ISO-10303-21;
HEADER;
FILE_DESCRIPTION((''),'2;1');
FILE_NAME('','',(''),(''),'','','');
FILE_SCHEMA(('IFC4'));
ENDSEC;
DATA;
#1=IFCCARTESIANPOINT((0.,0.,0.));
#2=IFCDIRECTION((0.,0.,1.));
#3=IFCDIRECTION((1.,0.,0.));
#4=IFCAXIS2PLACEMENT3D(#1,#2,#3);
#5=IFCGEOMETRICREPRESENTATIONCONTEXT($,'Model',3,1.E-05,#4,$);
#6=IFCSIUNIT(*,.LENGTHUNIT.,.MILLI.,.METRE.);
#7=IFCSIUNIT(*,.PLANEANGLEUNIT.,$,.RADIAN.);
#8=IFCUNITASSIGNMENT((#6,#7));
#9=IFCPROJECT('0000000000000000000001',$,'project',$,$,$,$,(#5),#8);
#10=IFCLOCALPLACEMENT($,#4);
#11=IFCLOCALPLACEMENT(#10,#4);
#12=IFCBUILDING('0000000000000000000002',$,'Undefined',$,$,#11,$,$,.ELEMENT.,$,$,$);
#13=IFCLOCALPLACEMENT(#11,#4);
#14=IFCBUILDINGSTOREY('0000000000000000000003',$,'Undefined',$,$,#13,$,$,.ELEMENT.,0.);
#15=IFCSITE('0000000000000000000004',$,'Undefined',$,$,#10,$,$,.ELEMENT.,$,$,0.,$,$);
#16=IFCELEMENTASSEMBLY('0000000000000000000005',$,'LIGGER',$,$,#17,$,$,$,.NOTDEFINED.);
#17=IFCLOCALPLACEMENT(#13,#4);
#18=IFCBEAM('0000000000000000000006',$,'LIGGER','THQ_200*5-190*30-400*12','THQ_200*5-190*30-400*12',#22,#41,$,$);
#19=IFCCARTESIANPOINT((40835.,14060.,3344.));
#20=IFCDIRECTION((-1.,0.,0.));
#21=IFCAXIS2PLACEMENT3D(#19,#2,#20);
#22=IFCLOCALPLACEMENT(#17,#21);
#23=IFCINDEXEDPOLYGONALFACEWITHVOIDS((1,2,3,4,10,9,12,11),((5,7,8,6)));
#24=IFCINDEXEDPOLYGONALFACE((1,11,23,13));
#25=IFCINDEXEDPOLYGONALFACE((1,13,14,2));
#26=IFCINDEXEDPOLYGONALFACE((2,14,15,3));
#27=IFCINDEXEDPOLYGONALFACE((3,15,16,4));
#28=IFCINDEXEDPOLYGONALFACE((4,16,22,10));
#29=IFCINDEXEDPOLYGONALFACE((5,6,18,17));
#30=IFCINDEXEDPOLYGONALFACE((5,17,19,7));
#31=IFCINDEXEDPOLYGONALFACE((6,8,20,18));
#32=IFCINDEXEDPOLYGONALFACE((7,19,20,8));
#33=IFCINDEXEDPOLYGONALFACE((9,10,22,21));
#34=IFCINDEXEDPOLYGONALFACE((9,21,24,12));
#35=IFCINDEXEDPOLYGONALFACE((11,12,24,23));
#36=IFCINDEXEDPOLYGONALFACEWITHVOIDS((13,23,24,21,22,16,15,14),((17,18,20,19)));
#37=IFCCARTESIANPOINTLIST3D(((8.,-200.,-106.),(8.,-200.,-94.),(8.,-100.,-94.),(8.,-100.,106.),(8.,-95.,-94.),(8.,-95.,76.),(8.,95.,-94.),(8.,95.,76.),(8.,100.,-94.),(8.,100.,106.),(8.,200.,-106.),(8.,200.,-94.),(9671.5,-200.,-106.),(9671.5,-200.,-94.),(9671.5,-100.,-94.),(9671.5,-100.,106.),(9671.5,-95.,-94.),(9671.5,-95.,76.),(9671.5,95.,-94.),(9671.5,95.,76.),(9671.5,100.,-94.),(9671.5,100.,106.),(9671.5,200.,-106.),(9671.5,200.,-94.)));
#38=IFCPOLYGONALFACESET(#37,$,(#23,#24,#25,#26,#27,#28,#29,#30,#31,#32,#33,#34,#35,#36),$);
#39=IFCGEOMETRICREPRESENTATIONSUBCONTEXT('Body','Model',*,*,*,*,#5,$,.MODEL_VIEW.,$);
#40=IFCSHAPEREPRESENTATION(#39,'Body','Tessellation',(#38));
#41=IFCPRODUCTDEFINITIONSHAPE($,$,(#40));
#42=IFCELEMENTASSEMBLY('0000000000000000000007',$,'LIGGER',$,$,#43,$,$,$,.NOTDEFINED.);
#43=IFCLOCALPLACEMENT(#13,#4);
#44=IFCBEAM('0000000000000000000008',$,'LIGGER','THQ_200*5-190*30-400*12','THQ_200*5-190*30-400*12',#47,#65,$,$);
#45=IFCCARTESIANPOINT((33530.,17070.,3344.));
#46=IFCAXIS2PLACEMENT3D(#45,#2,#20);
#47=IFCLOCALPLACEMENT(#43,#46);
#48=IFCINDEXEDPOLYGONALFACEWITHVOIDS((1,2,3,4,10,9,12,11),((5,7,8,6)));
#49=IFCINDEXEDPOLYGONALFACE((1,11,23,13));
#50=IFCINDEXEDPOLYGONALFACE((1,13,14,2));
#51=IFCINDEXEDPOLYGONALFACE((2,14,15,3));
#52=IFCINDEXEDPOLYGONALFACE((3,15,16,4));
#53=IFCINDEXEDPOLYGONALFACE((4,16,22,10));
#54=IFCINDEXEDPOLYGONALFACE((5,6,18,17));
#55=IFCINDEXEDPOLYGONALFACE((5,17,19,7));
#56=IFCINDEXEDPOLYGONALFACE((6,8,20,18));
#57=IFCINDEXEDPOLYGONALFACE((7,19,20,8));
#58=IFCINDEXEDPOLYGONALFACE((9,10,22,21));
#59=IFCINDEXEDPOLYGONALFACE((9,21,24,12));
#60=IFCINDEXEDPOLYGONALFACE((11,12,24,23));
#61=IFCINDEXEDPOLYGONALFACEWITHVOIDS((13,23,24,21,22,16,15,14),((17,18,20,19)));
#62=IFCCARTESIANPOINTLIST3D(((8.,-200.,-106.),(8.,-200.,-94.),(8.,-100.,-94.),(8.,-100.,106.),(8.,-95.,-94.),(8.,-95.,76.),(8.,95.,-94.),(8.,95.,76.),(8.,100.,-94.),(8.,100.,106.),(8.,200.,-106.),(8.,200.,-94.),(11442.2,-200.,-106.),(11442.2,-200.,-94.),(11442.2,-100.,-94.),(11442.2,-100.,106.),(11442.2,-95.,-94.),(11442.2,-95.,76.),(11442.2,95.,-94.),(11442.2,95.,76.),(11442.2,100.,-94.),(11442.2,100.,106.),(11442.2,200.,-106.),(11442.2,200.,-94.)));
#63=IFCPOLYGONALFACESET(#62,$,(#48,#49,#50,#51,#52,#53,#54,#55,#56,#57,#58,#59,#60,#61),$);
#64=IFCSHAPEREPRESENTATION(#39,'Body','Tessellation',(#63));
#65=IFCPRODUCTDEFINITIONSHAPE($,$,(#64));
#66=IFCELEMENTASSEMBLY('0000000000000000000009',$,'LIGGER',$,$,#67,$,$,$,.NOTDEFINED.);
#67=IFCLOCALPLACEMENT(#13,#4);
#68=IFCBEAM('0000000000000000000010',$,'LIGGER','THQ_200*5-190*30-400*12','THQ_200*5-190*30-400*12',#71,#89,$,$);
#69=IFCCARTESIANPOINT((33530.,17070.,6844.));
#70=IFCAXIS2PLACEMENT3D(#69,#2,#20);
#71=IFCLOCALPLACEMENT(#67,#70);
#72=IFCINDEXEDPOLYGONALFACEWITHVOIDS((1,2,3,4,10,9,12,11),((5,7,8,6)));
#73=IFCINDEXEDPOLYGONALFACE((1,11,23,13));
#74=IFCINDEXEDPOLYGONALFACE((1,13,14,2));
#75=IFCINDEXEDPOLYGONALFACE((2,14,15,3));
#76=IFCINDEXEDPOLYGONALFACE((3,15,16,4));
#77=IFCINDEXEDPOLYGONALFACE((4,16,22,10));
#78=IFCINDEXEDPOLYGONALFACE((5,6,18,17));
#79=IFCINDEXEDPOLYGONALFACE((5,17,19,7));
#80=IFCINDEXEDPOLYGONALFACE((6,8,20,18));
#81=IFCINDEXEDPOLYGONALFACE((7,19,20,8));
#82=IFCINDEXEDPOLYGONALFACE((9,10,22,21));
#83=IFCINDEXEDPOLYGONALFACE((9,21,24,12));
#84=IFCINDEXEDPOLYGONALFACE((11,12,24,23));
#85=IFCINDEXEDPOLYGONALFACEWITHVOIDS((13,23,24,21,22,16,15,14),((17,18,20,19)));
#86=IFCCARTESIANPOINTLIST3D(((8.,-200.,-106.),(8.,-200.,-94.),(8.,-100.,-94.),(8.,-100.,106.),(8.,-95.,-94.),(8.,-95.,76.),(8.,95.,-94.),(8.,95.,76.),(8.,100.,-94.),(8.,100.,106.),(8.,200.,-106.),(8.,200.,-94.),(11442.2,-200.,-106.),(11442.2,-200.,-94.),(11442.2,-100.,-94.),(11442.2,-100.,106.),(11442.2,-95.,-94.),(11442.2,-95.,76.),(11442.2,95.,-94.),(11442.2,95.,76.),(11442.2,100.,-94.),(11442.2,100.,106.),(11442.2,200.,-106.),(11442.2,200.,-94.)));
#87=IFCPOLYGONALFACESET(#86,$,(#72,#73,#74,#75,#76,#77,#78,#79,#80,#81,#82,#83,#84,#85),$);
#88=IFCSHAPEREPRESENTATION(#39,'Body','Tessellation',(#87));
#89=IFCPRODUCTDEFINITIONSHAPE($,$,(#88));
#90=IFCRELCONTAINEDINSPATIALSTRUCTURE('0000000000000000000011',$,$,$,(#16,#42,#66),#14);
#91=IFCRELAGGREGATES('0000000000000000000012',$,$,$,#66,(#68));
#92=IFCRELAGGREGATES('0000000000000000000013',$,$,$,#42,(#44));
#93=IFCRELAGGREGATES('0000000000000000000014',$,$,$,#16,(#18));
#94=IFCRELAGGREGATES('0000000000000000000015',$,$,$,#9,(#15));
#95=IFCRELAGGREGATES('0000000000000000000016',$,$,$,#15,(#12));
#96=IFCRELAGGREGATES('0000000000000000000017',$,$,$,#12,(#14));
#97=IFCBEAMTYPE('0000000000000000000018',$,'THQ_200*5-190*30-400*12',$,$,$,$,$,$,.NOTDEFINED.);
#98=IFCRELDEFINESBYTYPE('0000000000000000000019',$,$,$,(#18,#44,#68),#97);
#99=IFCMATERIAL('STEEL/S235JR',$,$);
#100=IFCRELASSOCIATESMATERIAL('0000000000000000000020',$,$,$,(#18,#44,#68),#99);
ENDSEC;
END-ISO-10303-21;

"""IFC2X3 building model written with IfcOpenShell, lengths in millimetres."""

from ifc_helpers import new_model, si_unit, frame, origin_with_axes, place, context, subcontext, project, spatial, polyline, outline, extrude, material, type_object, element, aggregate, save


model = new_model("IFC2X3")

# Units and contexts
model_context = context("Model", 3, precision=1e-05, world=origin_with_axes())
body_context = subcontext(model_context, "Body", "Model", "MODEL_VIEW")
ifc_project = project(units=[si_unit("LENGTHUNIT", "METRE", prefix="MILLI"), si_unit("PLANEANGLEUNIT", "RADIAN")], contexts=[model_context])

# Site, building, storey
site_placement = place(None, origin_with_axes())
site = spatial("IfcSite", under=ifc_project, at=site_placement, Name="Undefined", CompositionType="ELEMENT", RefElevation=0.0)
building_placement = place(site_placement, origin_with_axes())
building = spatial("IfcBuilding", under=site, at=building_placement, Name="Undefined", CompositionType="ELEMENT")
storey_placement = place(building_placement, origin_with_axes())
storey = spatial("IfcBuildingStorey", under=building, at=storey_placement, Name="Undefined", CompositionType="ELEMENT", Elevation=0.0)

# Shared definitions
ifc_material = material(Name="STEEL/S235JR")

# Element assemblies, beams
assembly_1_placement = place(storey_placement, origin_with_axes())
assembly_1 = element("IfcElementAssembly", 1, at=assembly_1_placement, inside=storey, Name="LIGGER", PredefinedType="NOTDEFINED")
beam_type_1 = type_object("IfcBeamType", Name="THQ_200*5-190*30-400*12", PredefinedType="NOTDEFINED")
beam_1_placement = place(assembly_1_placement, frame((40835.0, 14060.0, 3344.0), z_axis=(0.0, 0.0, 1.0), x_axis=(-1.0, 0.0, 0.0)))
beam_1 = element("IfcBeam", 2, at=beam_1_placement, type_object=beam_type_1, material=ifc_material, Name="LIGGER", Description="THQ_200*5-190*30-400*12", ObjectType="THQ_200*5-190*30-400*12", context=body_context, shape_type="SweptSolid", body=[
    extrude(outline(polyline([(100.0, -94.0), (200.0, -94.0), (200.0, -106.0), (-200.0, -106.0), (-200.0, -94.0), (-100.0, -94.0), (-100.0, 106.0), (100.0, 106.0), (100.0, -94.0)]), holes=[polyline([(95.0, -94.0), (95.0, 76.0), (-95.0, 76.0), (-95.0, -94.0), (95.0, -94.0)])]), frame((9671.5, 0.0, 0.0), z_axis=(-1.0, 0.0, 0.0), x_axis=(0.0, -1.0, 0.0)), (0.0, 0.0, 1.0), 9663.5),
])
assembly_2_placement = place(storey_placement, origin_with_axes())
assembly_2 = element("IfcElementAssembly", 3, at=assembly_2_placement, inside=storey, Name="LIGGER", PredefinedType="NOTDEFINED")
beam_2_placement = place(assembly_2_placement, frame((33530.0, 17070.0, 3344.0), z_axis=(0.0, 0.0, 1.0), x_axis=(-1.0, 0.0, 0.0)))
beam_2 = element("IfcBeam", 4, at=beam_2_placement, type_object=beam_type_1, material=ifc_material, Name="LIGGER", Description="THQ_200*5-190*30-400*12", ObjectType="THQ_200*5-190*30-400*12", context=body_context, shape_type="SweptSolid", body=[
    extrude(outline(polyline([(100.0, -94.0), (200.0, -94.0), (200.0, -106.0), (-200.0, -106.0), (-200.0, -94.0), (-100.0, -94.0), (-100.0, 106.0), (100.0, 106.0), (100.0, -94.0)]), holes=[polyline([(95.0, -94.0), (95.0, 76.0), (-95.0, 76.0), (-95.0, -94.0), (95.0, -94.0)])]), frame((11442.2, 0.0, 0.0), z_axis=(-1.0, 0.0, 0.0), x_axis=(0.0, -1.0, 0.0)), (0.0, 0.0, 1.0), 11434.2),
])
assembly_3_placement = place(storey_placement, origin_with_axes())
assembly_3 = element("IfcElementAssembly", 5, at=assembly_3_placement, inside=storey, Name="LIGGER", PredefinedType="NOTDEFINED")
beam_3_placement = place(assembly_3_placement, frame((33530.0, 17070.0, 6844.0), z_axis=(0.0, 0.0, 1.0), x_axis=(-1.0, 0.0, 0.0)))
beam_3 = element("IfcBeam", 6, at=beam_3_placement, type_object=beam_type_1, material=ifc_material, Name="LIGGER", Description="THQ_200*5-190*30-400*12", ObjectType="THQ_200*5-190*30-400*12", context=body_context, shape_type="SweptSolid", body=[
    extrude(outline(polyline([(100.0, -94.0), (200.0, -94.0), (200.0, -106.0), (-200.0, -106.0), (-200.0, -94.0), (-100.0, -94.0), (-100.0, 106.0), (100.0, 106.0), (100.0, -94.0)]), holes=[polyline([(95.0, -94.0), (95.0, 76.0), (-95.0, 76.0), (-95.0, -94.0), (95.0, -94.0)])]), frame((11442.2, 0.0, 0.0), z_axis=(-1.0, 0.0, 0.0), x_axis=(0.0, -1.0, 0.0)), (0.0, 0.0, 1.0), 11434.2),
])

aggregate(assembly_3, [beam_3])
aggregate(assembly_2, [beam_2])
aggregate(assembly_1, [beam_1])

save(model, "model.ifc")
